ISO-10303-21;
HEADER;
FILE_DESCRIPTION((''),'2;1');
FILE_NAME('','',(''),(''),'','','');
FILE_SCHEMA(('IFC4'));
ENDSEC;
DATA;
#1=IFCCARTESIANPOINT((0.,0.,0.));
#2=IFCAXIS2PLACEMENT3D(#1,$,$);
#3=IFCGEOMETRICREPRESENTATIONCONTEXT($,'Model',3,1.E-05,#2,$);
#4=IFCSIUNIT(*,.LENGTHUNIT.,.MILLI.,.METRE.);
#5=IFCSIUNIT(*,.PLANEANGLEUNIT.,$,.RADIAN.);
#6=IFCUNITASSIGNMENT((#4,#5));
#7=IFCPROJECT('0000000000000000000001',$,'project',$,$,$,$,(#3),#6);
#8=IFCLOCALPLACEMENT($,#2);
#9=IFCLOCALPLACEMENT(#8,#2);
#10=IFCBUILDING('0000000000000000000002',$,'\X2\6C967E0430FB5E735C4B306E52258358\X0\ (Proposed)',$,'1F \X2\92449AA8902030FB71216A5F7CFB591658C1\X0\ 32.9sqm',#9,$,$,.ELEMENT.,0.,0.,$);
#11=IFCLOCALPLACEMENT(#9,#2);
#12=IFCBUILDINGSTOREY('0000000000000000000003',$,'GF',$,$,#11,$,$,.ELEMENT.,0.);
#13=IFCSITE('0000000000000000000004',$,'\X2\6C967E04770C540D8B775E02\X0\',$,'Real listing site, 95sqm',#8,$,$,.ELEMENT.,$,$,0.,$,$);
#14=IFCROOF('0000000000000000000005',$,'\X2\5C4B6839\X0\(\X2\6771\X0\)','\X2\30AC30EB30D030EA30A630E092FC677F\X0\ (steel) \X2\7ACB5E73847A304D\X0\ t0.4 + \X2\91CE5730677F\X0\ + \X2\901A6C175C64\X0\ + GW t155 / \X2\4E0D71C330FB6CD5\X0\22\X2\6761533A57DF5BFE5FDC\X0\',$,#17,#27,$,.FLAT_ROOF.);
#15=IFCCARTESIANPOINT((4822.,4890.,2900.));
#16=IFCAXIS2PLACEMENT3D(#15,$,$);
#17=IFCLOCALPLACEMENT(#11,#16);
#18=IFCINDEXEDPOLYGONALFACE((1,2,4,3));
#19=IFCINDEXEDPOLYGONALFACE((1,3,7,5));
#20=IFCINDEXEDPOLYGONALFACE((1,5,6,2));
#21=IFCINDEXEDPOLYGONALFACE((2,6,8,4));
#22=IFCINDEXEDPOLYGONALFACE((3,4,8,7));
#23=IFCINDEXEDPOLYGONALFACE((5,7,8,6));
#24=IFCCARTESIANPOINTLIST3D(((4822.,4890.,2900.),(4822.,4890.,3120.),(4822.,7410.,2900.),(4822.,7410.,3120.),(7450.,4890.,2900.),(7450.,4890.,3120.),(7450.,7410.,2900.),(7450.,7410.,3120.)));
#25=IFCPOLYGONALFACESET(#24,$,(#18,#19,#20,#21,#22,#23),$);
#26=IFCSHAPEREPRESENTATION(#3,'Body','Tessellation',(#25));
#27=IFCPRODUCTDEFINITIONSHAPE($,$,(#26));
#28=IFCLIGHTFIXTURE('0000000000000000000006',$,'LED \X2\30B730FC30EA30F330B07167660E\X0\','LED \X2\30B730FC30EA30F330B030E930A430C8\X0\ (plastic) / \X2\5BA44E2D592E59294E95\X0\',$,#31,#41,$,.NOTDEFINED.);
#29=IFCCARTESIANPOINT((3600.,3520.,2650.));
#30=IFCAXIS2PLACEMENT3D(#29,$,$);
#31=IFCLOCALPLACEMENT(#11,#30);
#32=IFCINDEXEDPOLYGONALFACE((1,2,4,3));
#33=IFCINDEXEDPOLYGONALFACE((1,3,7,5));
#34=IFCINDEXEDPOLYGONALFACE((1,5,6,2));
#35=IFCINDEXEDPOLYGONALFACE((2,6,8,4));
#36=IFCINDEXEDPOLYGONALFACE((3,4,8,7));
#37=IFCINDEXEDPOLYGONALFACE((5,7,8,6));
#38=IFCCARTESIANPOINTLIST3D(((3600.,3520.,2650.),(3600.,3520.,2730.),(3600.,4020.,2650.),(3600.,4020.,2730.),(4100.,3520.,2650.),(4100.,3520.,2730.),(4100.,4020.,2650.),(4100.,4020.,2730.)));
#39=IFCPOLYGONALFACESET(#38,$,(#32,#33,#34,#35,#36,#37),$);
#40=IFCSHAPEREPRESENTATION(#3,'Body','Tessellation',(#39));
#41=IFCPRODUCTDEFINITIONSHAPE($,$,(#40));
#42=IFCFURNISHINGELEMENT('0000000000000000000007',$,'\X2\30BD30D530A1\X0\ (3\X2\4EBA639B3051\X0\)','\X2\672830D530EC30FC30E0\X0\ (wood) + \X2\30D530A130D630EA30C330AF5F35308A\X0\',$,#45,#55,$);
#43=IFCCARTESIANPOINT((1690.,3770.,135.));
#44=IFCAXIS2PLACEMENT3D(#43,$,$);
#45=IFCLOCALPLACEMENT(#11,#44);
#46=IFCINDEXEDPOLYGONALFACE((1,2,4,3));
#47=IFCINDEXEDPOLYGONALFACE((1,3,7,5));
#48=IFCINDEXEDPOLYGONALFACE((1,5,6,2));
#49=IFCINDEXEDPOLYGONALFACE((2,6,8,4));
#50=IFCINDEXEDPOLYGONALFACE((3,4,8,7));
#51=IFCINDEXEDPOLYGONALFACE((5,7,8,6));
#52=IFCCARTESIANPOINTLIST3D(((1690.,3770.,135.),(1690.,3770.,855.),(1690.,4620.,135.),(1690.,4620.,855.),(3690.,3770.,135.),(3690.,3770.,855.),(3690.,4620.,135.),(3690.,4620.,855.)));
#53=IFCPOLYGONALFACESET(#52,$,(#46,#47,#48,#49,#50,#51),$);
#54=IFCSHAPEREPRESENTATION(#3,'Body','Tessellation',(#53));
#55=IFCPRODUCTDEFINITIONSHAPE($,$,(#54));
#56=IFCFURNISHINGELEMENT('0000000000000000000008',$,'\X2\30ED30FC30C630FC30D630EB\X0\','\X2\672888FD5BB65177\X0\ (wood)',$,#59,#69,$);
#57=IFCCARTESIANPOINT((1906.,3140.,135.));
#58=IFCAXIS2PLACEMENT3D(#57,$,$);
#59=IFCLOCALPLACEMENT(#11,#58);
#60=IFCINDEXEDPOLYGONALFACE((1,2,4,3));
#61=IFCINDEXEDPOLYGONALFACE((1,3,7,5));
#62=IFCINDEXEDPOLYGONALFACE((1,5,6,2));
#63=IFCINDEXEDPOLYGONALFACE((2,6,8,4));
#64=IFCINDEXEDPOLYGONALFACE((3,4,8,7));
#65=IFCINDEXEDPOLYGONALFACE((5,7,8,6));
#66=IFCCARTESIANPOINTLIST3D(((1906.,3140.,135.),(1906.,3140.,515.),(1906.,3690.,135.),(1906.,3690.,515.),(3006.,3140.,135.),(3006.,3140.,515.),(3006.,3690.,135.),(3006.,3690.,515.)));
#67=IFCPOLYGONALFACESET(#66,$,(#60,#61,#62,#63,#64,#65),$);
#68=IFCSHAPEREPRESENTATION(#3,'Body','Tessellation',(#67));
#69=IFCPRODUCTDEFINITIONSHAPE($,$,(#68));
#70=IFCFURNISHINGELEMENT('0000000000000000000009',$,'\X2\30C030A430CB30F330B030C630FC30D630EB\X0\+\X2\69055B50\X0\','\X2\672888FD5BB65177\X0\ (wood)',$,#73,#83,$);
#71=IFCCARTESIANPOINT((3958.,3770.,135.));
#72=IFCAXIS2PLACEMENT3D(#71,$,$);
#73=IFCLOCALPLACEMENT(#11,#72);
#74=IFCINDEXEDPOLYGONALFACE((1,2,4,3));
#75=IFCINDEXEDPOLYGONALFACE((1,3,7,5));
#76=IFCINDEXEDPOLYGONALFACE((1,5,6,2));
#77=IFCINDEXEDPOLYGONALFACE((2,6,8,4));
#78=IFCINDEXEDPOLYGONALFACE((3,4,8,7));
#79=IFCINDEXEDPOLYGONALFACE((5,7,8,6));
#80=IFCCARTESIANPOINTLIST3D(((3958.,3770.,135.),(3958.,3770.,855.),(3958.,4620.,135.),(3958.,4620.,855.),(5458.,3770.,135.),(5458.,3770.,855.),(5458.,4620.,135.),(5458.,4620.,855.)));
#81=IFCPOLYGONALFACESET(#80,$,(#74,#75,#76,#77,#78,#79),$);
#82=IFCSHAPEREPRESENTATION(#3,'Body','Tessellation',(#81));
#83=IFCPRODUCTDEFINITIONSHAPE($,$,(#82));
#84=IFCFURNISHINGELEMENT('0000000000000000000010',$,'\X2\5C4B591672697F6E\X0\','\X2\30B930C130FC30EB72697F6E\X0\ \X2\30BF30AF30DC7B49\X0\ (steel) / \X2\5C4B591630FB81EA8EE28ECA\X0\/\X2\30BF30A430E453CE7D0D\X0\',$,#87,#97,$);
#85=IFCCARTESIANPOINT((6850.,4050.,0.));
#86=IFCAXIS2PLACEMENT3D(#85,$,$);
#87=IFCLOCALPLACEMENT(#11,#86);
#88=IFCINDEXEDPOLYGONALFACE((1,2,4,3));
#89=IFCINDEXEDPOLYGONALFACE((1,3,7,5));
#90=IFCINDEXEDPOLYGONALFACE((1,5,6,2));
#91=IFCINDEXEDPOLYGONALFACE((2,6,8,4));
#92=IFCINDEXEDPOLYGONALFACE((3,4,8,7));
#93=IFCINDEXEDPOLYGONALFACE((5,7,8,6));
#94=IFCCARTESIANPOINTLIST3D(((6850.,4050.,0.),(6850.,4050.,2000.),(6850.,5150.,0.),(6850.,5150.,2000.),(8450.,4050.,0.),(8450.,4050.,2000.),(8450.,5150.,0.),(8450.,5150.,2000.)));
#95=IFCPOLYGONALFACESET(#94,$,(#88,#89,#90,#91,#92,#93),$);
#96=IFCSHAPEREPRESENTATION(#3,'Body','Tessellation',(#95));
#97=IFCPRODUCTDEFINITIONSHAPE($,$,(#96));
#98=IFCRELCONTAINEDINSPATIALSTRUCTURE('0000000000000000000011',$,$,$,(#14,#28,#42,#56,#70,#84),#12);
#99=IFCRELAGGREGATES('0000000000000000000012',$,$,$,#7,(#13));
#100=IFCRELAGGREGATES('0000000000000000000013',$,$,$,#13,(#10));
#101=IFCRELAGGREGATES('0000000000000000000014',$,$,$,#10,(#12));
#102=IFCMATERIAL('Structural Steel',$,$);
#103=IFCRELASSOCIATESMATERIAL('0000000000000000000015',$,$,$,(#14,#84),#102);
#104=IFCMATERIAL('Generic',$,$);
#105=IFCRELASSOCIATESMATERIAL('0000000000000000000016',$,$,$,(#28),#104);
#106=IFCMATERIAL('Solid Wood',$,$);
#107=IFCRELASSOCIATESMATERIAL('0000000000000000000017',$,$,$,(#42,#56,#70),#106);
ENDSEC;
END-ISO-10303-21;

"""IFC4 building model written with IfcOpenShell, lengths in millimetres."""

from ifc_helpers import new_model, si_unit, frame, frame_2d, origin, place, context, project, spatial, rectangle, extrude, material, element, save


model = new_model("IFC4")

# Units and contexts
model_context = context("Model", 3, precision=1e-05, world=origin())
ifc_project = project(units=[si_unit("LENGTHUNIT", "METRE", prefix="MILLI"), si_unit("PLANEANGLEUNIT", "RADIAN")], contexts=[model_context])

# Site, building, storey
site_placement = place(None, origin())
site = spatial("IfcSite", under=ifc_project, at=site_placement, Name="沖縄県名護市", ObjectType="Real listing site, 95sqm", CompositionType="ELEMENT", RefElevation=0.0)
building_placement = place(site_placement, origin())
building = spatial("IfcBuilding", under=site, at=building_placement, Name="沖縄・平屋の別荘 (Proposed)", ObjectType="1F 鉄骨造・無機系外壁 32.9sqm", CompositionType="ELEMENT", ElevationOfRefHeight=0.0, ElevationOfTerrain=0.0)
storey_placement = place(building_placement, origin())
storey = spatial("IfcBuildingStorey", under=building, at=storey_placement, Name="GF", CompositionType="ELEMENT", Elevation=0.0)

# Shared definitions
ifc_material_1 = material(Name="Solid Wood")

# Roof
ifc_material_2 = material(Name="Structural Steel")
roof_1_placement = place(storey_placement, frame((4822.0, 4890.0, 2900.0)))
element("IfcRoof", 1, at=roof_1_placement, inside=storey, material=ifc_material_2, Name="屋根(東)", Description="ガルバリウム鋼板 (steel) 立平葺き t0.4 + 野地板 + 通気層 + GW t155 / 不燃・法22条区域対応", PredefinedType="FLAT_ROOF", context=model_context, shape_type="SweptSolid", body=[
    extrude(rectangle(XDim=2628.0, YDim=2520.0, at=frame_2d((1314.0, 1260.0))), frame((4822.0, 4890.0, 2900.0)), (0.0, 0.0, 1.0), 220.0),
])

# Light fixture
ifc_material_3 = material(Name="Generic")
light_fixture_placement = place(storey_placement, frame((3600.0, 3520.0, 2650.0)))
element("IfcLightFixture", 2, at=light_fixture_placement, inside=storey, material=ifc_material_3, Name="LED シーリング照明", Description="LED シーリングライト (plastic) / 室中央天井", PredefinedType="NOTDEFINED", context=model_context, shape_type="SweptSolid", body=[
    extrude(rectangle(XDim=500.0, YDim=500.0, at=frame_2d((250.0, 250.0))), frame((3600.0, 3520.0, 2650.0)), (0.0, 0.0, 1.0), 80.0),
])

# Furnishing elements
furnishing_1_placement = place(storey_placement, frame((1690.0, 3770.0, 135.0)))
element("IfcFurnishingElement", 3, at=furnishing_1_placement, inside=storey, material=ifc_material_1, Name="ソファ (3人掛け)", Description="木フレーム (wood) + ファブリック張り", context=model_context, shape_type="SweptSolid", body=[
    extrude(rectangle(XDim=2000.0, YDim=850.0, at=frame_2d((1000.0, 425.0))), frame((1690.0, 3770.0, 135.0)), (0.0, 0.0, 1.0), 720.0),
])
furnishing_2_placement = place(storey_placement, frame((1906.0, 3140.0, 135.0)))
element("IfcFurnishingElement", 4, at=furnishing_2_placement, inside=storey, material=ifc_material_1, Name="ローテーブル", Description="木製家具 (wood)", context=model_context, shape_type="SweptSolid", body=[
    extrude(rectangle(XDim=1100.0, YDim=550.0, at=frame_2d((550.0, 275.0))), frame((1906.0, 3140.0, 135.0)), (0.0, 0.0, 1.0), 380.0),
])
furnishing_3_placement = place(storey_placement, frame((3958.0, 3770.0, 135.0)))
element("IfcFurnishingElement", 5, at=furnishing_3_placement, inside=storey, material=ifc_material_1, Name="ダイニングテーブル+椅子", Description="木製家具 (wood)", context=model_context, shape_type="SweptSolid", body=[
    extrude(rectangle(XDim=1500.0, YDim=850.0, at=frame_2d((750.0, 425.0))), frame((3958.0, 3770.0, 135.0)), (0.0, 0.0, 1.0), 720.0),
])
furnishing_4_placement = place(storey_placement, frame((6850.0, 4050.0, 0.0)))
element("IfcFurnishingElement", 6, at=furnishing_4_placement, inside=storey, material=ifc_material_2, Name="屋外物置", Description="スチール物置 タクボ等 (steel) / 屋外・自転車/タイヤ収納", context=model_context, shape_type="SweptSolid", body=[
    extrude(rectangle(XDim=1600.0, YDim=1100.0, at=frame_2d((800.0, 550.0))), frame((6850.0, 4050.0, 0.0)), (0.0, 0.0, 1.0), 2000.0),
])

save(model, "model.ifc")
